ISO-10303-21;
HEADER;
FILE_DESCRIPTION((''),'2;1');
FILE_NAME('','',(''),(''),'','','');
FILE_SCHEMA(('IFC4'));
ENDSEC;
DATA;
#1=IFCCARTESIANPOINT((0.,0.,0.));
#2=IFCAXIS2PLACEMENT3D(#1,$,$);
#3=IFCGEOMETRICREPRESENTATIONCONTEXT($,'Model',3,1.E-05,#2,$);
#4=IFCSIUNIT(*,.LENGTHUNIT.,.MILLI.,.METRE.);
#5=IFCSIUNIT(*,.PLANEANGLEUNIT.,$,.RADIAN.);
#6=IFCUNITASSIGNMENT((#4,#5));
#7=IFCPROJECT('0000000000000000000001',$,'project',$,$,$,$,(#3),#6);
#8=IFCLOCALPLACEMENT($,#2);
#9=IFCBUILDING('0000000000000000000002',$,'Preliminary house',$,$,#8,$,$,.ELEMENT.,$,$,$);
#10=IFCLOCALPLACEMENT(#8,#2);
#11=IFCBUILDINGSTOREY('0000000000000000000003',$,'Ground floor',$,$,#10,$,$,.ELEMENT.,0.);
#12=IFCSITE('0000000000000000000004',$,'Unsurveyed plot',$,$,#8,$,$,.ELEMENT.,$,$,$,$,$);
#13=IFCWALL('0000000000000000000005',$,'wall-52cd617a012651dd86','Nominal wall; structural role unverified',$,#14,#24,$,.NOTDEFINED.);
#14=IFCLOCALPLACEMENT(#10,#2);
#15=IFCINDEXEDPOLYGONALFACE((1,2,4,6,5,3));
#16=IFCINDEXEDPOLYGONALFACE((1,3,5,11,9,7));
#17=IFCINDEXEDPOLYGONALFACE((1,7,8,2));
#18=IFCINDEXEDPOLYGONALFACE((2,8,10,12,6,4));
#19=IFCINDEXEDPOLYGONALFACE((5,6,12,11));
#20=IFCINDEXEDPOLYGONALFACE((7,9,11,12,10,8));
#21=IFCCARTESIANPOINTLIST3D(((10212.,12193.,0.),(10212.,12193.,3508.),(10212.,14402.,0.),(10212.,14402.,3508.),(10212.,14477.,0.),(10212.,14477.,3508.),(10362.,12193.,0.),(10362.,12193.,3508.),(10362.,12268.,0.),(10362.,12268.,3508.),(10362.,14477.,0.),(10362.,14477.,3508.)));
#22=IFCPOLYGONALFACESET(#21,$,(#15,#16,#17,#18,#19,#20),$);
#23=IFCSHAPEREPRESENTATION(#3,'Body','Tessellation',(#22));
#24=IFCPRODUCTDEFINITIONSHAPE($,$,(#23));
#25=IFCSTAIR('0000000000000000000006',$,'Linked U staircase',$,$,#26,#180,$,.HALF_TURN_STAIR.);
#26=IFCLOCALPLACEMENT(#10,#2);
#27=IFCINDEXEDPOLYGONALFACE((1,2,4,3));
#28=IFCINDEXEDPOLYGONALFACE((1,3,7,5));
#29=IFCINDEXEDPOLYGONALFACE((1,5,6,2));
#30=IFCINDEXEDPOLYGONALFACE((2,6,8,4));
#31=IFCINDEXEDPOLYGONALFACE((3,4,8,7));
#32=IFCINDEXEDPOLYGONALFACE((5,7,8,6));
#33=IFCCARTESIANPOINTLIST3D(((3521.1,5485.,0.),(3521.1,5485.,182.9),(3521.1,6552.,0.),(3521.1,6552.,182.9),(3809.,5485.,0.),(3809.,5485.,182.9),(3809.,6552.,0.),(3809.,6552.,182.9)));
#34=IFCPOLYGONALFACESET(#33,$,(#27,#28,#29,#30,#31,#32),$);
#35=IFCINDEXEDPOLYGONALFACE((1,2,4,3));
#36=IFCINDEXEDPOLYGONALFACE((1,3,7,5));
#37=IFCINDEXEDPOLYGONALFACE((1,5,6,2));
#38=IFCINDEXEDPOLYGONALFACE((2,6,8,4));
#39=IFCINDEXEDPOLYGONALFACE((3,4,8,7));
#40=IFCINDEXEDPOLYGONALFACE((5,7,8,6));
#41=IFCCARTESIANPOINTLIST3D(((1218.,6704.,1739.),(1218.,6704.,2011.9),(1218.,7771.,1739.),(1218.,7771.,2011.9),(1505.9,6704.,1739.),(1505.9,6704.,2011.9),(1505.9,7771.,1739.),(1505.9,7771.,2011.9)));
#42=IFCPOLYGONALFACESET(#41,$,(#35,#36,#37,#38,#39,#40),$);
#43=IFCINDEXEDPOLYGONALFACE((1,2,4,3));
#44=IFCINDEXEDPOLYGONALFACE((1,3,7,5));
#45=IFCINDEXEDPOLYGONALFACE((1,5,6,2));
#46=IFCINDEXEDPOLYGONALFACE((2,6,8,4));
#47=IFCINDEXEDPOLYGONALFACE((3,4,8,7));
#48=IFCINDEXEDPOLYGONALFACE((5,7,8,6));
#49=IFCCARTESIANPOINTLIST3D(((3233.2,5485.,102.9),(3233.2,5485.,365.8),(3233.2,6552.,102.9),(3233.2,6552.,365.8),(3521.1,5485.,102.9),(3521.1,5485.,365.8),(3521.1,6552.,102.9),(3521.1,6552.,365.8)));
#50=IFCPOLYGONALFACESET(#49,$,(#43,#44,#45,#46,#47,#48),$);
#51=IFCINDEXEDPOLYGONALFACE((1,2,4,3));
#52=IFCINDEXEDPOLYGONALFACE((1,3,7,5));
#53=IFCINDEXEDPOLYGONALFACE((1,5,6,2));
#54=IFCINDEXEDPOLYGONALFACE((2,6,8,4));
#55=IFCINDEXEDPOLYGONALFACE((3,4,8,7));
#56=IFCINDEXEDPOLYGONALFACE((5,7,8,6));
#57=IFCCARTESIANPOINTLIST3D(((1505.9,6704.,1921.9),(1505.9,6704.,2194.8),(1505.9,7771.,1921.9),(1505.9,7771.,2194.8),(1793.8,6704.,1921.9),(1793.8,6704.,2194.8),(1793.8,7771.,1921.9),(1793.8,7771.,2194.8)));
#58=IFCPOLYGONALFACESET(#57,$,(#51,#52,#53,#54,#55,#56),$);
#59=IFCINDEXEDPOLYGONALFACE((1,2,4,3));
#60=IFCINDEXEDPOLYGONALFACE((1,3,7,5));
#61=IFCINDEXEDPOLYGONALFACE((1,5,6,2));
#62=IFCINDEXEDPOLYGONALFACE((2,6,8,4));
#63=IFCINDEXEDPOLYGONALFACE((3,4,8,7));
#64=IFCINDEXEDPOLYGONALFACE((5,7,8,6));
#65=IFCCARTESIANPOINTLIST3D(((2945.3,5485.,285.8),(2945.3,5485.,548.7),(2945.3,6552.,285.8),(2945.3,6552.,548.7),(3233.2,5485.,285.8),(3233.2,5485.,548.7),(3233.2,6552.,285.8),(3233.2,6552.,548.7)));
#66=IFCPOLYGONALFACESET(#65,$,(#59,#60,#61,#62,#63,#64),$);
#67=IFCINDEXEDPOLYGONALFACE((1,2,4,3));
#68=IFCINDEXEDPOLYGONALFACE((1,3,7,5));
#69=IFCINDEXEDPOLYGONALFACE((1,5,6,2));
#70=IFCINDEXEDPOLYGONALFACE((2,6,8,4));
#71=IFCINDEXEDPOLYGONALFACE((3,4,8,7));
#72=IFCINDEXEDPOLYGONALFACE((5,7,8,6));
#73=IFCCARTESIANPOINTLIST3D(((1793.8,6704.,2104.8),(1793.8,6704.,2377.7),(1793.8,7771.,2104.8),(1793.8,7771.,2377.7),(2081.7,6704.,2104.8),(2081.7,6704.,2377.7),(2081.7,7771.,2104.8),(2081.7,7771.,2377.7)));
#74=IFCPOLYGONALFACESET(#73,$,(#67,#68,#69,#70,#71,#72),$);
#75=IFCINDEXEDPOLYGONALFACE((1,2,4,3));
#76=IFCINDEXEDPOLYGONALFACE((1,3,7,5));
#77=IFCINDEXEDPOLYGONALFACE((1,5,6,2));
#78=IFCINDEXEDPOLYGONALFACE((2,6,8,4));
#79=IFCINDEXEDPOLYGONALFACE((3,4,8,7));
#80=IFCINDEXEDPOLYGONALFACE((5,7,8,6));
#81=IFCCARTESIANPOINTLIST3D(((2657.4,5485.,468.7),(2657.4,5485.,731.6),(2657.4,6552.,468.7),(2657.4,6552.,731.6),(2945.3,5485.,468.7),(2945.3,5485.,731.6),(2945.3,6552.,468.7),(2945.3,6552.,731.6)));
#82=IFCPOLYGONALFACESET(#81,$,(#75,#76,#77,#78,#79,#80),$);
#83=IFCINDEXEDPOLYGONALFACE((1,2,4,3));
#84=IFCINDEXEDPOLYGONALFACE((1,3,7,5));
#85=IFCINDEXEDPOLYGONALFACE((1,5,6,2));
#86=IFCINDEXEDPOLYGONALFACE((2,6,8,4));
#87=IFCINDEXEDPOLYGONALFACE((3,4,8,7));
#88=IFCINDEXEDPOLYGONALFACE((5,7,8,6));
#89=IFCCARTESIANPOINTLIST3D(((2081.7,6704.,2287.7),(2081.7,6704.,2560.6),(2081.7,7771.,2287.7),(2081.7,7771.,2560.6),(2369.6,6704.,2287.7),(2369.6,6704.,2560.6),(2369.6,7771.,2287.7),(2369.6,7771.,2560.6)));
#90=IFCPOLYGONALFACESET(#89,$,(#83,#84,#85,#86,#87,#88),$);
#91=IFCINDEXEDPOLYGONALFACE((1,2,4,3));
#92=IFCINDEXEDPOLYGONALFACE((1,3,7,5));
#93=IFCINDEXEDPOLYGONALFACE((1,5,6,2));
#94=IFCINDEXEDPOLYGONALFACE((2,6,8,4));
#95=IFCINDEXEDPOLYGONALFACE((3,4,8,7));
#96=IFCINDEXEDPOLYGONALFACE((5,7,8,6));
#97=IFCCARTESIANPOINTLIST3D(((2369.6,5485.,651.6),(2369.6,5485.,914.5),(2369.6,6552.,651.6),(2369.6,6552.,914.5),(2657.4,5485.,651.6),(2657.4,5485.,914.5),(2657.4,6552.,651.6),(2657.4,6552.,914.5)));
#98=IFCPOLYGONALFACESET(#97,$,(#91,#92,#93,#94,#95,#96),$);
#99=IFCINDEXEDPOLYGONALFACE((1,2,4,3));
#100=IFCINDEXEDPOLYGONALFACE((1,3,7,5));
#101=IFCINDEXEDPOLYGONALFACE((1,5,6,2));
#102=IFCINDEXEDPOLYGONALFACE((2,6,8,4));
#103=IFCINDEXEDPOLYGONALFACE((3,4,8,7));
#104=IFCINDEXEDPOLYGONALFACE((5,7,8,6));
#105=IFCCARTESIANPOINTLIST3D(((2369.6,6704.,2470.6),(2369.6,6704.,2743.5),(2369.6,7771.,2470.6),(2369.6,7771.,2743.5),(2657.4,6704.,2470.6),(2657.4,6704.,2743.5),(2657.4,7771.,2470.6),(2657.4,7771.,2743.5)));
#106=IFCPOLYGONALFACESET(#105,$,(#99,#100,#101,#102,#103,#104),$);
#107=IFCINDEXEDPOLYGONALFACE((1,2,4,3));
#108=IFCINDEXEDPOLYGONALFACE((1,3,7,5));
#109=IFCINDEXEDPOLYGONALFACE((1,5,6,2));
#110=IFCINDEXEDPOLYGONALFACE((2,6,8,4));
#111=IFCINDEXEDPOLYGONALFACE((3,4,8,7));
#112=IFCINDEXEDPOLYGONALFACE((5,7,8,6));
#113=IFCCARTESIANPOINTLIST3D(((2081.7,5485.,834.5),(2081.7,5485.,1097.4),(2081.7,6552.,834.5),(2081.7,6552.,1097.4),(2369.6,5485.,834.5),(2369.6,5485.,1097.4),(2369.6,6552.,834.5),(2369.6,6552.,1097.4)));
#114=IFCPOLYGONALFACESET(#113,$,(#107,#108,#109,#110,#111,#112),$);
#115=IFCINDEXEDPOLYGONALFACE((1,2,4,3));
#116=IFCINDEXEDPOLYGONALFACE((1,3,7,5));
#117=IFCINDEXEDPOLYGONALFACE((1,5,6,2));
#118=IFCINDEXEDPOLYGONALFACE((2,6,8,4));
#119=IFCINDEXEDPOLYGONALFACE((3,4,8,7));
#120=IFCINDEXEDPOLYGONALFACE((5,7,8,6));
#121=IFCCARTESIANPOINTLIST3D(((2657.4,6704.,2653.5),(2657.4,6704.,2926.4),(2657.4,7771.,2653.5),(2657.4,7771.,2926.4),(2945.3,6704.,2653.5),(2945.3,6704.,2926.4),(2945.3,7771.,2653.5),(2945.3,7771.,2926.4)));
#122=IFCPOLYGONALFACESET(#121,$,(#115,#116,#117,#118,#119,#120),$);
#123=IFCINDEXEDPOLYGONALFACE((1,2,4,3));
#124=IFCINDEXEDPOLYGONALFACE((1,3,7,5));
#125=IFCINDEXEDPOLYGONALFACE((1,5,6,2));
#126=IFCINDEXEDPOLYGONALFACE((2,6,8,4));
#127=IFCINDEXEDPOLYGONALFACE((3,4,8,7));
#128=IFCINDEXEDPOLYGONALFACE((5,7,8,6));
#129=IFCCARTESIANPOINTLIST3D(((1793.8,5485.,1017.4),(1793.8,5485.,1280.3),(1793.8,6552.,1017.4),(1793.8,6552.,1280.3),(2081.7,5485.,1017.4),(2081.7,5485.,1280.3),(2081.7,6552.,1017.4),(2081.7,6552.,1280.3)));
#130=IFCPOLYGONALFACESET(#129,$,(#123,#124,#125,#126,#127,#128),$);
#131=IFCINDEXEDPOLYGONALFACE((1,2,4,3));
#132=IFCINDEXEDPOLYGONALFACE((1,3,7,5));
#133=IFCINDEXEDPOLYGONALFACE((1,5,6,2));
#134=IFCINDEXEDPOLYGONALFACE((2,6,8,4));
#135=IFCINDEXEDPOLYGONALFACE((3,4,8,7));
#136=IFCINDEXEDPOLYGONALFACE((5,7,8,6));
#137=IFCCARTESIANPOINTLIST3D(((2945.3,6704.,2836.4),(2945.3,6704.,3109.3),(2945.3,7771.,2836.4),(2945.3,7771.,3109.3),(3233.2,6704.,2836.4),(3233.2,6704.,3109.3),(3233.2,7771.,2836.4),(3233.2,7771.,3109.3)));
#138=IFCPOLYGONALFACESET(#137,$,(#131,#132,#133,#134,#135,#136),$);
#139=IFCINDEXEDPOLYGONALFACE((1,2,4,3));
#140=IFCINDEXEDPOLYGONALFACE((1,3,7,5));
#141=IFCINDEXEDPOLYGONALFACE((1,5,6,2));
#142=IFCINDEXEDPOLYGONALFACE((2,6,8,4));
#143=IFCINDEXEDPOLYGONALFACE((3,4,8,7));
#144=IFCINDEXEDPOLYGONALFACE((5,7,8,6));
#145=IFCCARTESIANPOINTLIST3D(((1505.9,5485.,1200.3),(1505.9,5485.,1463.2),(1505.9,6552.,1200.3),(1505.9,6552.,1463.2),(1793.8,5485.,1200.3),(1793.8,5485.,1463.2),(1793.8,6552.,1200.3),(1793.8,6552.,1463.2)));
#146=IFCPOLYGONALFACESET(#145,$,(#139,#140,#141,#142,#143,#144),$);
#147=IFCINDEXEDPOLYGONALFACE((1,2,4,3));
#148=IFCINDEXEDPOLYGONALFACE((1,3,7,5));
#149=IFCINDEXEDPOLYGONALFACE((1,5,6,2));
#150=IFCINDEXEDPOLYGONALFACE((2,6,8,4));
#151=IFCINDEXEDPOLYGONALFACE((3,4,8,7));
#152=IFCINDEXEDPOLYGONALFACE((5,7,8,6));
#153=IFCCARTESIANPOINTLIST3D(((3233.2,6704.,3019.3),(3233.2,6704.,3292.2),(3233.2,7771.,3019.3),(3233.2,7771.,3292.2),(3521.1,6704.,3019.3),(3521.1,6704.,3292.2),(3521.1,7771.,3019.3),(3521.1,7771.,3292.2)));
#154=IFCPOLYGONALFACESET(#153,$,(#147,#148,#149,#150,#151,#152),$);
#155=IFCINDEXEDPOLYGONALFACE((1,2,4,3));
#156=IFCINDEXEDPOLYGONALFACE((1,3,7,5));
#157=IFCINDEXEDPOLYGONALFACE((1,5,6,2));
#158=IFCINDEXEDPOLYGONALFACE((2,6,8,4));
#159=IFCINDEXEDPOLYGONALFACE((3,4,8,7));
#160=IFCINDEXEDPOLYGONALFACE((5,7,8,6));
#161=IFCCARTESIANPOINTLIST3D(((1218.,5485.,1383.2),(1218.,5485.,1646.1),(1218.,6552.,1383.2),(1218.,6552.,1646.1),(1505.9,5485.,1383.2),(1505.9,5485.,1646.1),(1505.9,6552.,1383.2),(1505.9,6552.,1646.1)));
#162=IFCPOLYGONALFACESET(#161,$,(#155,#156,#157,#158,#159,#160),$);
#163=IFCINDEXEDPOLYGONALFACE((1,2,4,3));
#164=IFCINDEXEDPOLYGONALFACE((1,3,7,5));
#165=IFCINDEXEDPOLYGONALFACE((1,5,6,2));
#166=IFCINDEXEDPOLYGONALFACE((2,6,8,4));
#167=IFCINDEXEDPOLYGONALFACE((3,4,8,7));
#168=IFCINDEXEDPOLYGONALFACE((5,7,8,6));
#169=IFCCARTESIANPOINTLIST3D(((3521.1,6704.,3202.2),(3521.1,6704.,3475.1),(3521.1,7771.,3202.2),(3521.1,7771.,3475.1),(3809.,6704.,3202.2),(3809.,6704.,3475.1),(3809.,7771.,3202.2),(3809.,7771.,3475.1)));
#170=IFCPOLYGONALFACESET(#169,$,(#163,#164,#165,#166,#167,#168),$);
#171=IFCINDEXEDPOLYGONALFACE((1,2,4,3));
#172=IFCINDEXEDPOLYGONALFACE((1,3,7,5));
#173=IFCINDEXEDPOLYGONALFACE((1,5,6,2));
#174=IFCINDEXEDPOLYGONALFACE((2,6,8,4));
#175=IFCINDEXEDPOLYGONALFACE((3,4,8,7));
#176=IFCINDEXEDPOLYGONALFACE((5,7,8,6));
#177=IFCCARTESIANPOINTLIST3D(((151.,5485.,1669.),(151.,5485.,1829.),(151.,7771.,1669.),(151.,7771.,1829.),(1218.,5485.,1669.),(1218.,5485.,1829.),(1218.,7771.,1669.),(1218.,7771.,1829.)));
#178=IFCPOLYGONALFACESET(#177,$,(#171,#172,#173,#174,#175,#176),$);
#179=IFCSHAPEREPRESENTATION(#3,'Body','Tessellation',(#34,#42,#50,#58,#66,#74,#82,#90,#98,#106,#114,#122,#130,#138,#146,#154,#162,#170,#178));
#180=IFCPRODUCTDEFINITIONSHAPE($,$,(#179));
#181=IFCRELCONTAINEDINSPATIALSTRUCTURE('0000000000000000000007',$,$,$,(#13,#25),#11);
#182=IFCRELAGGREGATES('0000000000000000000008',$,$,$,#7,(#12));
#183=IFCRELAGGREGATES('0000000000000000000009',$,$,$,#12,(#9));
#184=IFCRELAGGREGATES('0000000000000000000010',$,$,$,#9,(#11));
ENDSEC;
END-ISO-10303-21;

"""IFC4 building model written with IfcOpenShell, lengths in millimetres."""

from ifc_helpers import new_model, si_unit, frame, origin, place, context, project, spatial, polyline, outline, extrude, element, save


model = new_model("IFC4")

# Units and contexts
model_context = context("Model", 3, precision=1e-05, world=origin())
ifc_project = project(units=[si_unit("LENGTHUNIT", "METRE", prefix="MILLI"), si_unit("PLANEANGLEUNIT", "RADIAN")], contexts=[model_context])

# Site, building, storey
placement_1 = place(None, origin())
site = spatial("IfcSite", under=ifc_project, at=placement_1, Name="Unsurveyed plot", CompositionType="ELEMENT")
building = spatial("IfcBuilding", under=site, at=placement_1, Name="Preliminary house", CompositionType="ELEMENT")
placement_2 = place(placement_1, origin())
storey = spatial("IfcBuildingStorey", under=building, at=placement_2, Name="Ground floor", CompositionType="ELEMENT", Elevation=0.0)

# Wall
element("IfcWall", 1, at=placement_2, inside=storey, Name="wall-52cd617a012651dd86", Description="Nominal wall; structural role unverified", PredefinedType="NOTDEFINED", context=model_context, shape_type="SweptSolid", body=[
    extrude(outline(polyline([(10212.0, 14402.0), (10212.0, 14477.0), (10362.0, 14477.0), (10362.0, 12268.0), (10362.0, 12193.0), (10212.0, 12193.0), (10212.0, 14402.0)])), origin(), (0.0, 0.0, 1.0), 3508.0),
])

# Stair
element("IfcStair", 2, at=placement_2, inside=storey, Name="Linked U staircase", PredefinedType="HALF_TURN_STAIR", context=model_context, shape_type="SweptSolid", body=[
    extrude(outline(polyline([(3809.0, 6552.0), (3521.1, 6552.0), (3521.1, 5485.0), (3809.0, 5485.0), (3809.0, 6552.0)])), origin(), (0.0, 0.0, 1.0), 182.9),
    extrude(outline(polyline([(1505.9, 7771.0), (1218.0, 7771.0), (1218.0, 6704.0), (1505.9, 6704.0), (1505.9, 7771.0)])), frame((0.0, 0.0, 1739.0)), (0.0, 0.0, 1.0), 272.9),
    extrude(outline(polyline([(3521.1, 6552.0), (3233.2, 6552.0), (3233.2, 5485.0), (3521.1, 5485.0), (3521.1, 6552.0)])), frame((0.0, 0.0, 102.9)), (0.0, 0.0, 1.0), 262.9),
    extrude(outline(polyline([(1793.8, 7771.0), (1505.9, 7771.0), (1505.9, 6704.0), (1793.8, 6704.0), (1793.8, 7771.0)])), frame((0.0, 0.0, 1921.9)), (0.0, 0.0, 1.0), 272.9),
    extrude(outline(polyline([(3233.2, 6552.0), (2945.3, 6552.0), (2945.3, 5485.0), (3233.2, 5485.0), (3233.2, 6552.0)])), frame((0.0, 0.0, 285.8)), (0.0, 0.0, 1.0), 262.9),
    extrude(outline(polyline([(2081.7, 7771.0), (1793.8, 7771.0), (1793.8, 6704.0), (2081.7, 6704.0), (2081.7, 7771.0)])), frame((0.0, 0.0, 2104.8)), (0.0, 0.0, 1.0), 272.9),
    extrude(outline(polyline([(2945.3, 6552.0), (2657.4, 6552.0), (2657.4, 5485.0), (2945.3, 5485.0), (2945.3, 6552.0)])), frame((0.0, 0.0, 468.7)), (0.0, 0.0, 1.0), 262.9),
    extrude(outline(polyline([(2369.6, 7771.0), (2081.7, 7771.0), (2081.7, 6704.0), (2369.6, 6704.0), (2369.6, 7771.0)])), frame((0.0, 0.0, 2287.7)), (0.0, 0.0, 1.0), 272.9),
    extrude(outline(polyline([(2657.4, 6552.0), (2369.6, 6552.0), (2369.6, 5485.0), (2657.4, 5485.0), (2657.4, 6552.0)])), frame((0.0, 0.0, 651.6)), (0.0, 0.0, 1.0), 262.9),
    extrude(outline(polyline([(2657.4, 7771.0), (2369.6, 7771.0), (2369.6, 6704.0), (2657.4, 6704.0), (2657.4, 7771.0)])), frame((0.0, 0.0, 2470.6)), (0.0, 0.0, 1.0), 272.9),
    extrude(outline(polyline([(2369.6, 6552.0), (2081.7, 6552.0), (2081.7, 5485.0), (2369.6, 5485.0), (2369.6, 6552.0)])), frame((0.0, 0.0, 834.5)), (0.0, 0.0, 1.0), 262.9),
    extrude(outline(polyline([(2945.3, 7771.0), (2657.4, 7771.0), (2657.4, 6704.0), (2945.3, 6704.0), (2945.3, 7771.0)])), frame((0.0, 0.0, 2653.5)), (0.0, 0.0, 1.0), 272.9),
    extrude(outline(polyline([(2081.7, 6552.0), (1793.8, 6552.0), (1793.8, 5485.0), (2081.7, 5485.0), (2081.7, 6552.0)])), frame((0.0, 0.0, 1017.4)), (0.0, 0.0, 1.0), 262.9),
    extrude(outline(polyline([(3233.2, 7771.0), (2945.3, 7771.0), (2945.3, 6704.0), (3233.2, 6704.0), (3233.2, 7771.0)])), frame((0.0, 0.0, 2836.4)), (0.0, 0.0, 1.0), 272.9),
    extrude(outline(polyline([(1793.8, 6552.0), (1505.9, 6552.0), (1505.9, 5485.0), (1793.8, 5485.0), (1793.8, 6552.0)])), frame((0.0, 0.0, 1200.3)), (0.0, 0.0, 1.0), 262.9),
    extrude(outline(polyline([(3521.1, 7771.0), (3233.2, 7771.0), (3233.2, 6704.0), (3521.1, 6704.0), (3521.1, 7771.0)])), frame((0.0, 0.0, 3019.3)), (0.0, 0.0, 1.0), 272.9),
    extrude(outline(polyline([(1505.9, 6552.0), (1218.0, 6552.0), (1218.0, 5485.0), (1505.9, 5485.0), (1505.9, 6552.0)])), frame((0.0, 0.0, 1383.2)), (0.0, 0.0, 1.0), 262.9),
    extrude(outline(polyline([(3809.0, 7771.0), (3521.1, 7771.0), (3521.1, 6704.0), (3809.0, 6704.0), (3809.0, 7771.0)])), frame((0.0, 0.0, 3202.2)), (0.0, 0.0, 1.0), 272.9),
    extrude(outline(polyline([(1218.0, 7771.0), (151.0, 7771.0), (151.0, 5485.0), (1218.0, 5485.0), (1218.0, 7771.0)])), frame((0.0, 0.0, 1669.0)), (0.0, 0.0, 1.0), 160.0),
])

save(model, "model.ifc")
